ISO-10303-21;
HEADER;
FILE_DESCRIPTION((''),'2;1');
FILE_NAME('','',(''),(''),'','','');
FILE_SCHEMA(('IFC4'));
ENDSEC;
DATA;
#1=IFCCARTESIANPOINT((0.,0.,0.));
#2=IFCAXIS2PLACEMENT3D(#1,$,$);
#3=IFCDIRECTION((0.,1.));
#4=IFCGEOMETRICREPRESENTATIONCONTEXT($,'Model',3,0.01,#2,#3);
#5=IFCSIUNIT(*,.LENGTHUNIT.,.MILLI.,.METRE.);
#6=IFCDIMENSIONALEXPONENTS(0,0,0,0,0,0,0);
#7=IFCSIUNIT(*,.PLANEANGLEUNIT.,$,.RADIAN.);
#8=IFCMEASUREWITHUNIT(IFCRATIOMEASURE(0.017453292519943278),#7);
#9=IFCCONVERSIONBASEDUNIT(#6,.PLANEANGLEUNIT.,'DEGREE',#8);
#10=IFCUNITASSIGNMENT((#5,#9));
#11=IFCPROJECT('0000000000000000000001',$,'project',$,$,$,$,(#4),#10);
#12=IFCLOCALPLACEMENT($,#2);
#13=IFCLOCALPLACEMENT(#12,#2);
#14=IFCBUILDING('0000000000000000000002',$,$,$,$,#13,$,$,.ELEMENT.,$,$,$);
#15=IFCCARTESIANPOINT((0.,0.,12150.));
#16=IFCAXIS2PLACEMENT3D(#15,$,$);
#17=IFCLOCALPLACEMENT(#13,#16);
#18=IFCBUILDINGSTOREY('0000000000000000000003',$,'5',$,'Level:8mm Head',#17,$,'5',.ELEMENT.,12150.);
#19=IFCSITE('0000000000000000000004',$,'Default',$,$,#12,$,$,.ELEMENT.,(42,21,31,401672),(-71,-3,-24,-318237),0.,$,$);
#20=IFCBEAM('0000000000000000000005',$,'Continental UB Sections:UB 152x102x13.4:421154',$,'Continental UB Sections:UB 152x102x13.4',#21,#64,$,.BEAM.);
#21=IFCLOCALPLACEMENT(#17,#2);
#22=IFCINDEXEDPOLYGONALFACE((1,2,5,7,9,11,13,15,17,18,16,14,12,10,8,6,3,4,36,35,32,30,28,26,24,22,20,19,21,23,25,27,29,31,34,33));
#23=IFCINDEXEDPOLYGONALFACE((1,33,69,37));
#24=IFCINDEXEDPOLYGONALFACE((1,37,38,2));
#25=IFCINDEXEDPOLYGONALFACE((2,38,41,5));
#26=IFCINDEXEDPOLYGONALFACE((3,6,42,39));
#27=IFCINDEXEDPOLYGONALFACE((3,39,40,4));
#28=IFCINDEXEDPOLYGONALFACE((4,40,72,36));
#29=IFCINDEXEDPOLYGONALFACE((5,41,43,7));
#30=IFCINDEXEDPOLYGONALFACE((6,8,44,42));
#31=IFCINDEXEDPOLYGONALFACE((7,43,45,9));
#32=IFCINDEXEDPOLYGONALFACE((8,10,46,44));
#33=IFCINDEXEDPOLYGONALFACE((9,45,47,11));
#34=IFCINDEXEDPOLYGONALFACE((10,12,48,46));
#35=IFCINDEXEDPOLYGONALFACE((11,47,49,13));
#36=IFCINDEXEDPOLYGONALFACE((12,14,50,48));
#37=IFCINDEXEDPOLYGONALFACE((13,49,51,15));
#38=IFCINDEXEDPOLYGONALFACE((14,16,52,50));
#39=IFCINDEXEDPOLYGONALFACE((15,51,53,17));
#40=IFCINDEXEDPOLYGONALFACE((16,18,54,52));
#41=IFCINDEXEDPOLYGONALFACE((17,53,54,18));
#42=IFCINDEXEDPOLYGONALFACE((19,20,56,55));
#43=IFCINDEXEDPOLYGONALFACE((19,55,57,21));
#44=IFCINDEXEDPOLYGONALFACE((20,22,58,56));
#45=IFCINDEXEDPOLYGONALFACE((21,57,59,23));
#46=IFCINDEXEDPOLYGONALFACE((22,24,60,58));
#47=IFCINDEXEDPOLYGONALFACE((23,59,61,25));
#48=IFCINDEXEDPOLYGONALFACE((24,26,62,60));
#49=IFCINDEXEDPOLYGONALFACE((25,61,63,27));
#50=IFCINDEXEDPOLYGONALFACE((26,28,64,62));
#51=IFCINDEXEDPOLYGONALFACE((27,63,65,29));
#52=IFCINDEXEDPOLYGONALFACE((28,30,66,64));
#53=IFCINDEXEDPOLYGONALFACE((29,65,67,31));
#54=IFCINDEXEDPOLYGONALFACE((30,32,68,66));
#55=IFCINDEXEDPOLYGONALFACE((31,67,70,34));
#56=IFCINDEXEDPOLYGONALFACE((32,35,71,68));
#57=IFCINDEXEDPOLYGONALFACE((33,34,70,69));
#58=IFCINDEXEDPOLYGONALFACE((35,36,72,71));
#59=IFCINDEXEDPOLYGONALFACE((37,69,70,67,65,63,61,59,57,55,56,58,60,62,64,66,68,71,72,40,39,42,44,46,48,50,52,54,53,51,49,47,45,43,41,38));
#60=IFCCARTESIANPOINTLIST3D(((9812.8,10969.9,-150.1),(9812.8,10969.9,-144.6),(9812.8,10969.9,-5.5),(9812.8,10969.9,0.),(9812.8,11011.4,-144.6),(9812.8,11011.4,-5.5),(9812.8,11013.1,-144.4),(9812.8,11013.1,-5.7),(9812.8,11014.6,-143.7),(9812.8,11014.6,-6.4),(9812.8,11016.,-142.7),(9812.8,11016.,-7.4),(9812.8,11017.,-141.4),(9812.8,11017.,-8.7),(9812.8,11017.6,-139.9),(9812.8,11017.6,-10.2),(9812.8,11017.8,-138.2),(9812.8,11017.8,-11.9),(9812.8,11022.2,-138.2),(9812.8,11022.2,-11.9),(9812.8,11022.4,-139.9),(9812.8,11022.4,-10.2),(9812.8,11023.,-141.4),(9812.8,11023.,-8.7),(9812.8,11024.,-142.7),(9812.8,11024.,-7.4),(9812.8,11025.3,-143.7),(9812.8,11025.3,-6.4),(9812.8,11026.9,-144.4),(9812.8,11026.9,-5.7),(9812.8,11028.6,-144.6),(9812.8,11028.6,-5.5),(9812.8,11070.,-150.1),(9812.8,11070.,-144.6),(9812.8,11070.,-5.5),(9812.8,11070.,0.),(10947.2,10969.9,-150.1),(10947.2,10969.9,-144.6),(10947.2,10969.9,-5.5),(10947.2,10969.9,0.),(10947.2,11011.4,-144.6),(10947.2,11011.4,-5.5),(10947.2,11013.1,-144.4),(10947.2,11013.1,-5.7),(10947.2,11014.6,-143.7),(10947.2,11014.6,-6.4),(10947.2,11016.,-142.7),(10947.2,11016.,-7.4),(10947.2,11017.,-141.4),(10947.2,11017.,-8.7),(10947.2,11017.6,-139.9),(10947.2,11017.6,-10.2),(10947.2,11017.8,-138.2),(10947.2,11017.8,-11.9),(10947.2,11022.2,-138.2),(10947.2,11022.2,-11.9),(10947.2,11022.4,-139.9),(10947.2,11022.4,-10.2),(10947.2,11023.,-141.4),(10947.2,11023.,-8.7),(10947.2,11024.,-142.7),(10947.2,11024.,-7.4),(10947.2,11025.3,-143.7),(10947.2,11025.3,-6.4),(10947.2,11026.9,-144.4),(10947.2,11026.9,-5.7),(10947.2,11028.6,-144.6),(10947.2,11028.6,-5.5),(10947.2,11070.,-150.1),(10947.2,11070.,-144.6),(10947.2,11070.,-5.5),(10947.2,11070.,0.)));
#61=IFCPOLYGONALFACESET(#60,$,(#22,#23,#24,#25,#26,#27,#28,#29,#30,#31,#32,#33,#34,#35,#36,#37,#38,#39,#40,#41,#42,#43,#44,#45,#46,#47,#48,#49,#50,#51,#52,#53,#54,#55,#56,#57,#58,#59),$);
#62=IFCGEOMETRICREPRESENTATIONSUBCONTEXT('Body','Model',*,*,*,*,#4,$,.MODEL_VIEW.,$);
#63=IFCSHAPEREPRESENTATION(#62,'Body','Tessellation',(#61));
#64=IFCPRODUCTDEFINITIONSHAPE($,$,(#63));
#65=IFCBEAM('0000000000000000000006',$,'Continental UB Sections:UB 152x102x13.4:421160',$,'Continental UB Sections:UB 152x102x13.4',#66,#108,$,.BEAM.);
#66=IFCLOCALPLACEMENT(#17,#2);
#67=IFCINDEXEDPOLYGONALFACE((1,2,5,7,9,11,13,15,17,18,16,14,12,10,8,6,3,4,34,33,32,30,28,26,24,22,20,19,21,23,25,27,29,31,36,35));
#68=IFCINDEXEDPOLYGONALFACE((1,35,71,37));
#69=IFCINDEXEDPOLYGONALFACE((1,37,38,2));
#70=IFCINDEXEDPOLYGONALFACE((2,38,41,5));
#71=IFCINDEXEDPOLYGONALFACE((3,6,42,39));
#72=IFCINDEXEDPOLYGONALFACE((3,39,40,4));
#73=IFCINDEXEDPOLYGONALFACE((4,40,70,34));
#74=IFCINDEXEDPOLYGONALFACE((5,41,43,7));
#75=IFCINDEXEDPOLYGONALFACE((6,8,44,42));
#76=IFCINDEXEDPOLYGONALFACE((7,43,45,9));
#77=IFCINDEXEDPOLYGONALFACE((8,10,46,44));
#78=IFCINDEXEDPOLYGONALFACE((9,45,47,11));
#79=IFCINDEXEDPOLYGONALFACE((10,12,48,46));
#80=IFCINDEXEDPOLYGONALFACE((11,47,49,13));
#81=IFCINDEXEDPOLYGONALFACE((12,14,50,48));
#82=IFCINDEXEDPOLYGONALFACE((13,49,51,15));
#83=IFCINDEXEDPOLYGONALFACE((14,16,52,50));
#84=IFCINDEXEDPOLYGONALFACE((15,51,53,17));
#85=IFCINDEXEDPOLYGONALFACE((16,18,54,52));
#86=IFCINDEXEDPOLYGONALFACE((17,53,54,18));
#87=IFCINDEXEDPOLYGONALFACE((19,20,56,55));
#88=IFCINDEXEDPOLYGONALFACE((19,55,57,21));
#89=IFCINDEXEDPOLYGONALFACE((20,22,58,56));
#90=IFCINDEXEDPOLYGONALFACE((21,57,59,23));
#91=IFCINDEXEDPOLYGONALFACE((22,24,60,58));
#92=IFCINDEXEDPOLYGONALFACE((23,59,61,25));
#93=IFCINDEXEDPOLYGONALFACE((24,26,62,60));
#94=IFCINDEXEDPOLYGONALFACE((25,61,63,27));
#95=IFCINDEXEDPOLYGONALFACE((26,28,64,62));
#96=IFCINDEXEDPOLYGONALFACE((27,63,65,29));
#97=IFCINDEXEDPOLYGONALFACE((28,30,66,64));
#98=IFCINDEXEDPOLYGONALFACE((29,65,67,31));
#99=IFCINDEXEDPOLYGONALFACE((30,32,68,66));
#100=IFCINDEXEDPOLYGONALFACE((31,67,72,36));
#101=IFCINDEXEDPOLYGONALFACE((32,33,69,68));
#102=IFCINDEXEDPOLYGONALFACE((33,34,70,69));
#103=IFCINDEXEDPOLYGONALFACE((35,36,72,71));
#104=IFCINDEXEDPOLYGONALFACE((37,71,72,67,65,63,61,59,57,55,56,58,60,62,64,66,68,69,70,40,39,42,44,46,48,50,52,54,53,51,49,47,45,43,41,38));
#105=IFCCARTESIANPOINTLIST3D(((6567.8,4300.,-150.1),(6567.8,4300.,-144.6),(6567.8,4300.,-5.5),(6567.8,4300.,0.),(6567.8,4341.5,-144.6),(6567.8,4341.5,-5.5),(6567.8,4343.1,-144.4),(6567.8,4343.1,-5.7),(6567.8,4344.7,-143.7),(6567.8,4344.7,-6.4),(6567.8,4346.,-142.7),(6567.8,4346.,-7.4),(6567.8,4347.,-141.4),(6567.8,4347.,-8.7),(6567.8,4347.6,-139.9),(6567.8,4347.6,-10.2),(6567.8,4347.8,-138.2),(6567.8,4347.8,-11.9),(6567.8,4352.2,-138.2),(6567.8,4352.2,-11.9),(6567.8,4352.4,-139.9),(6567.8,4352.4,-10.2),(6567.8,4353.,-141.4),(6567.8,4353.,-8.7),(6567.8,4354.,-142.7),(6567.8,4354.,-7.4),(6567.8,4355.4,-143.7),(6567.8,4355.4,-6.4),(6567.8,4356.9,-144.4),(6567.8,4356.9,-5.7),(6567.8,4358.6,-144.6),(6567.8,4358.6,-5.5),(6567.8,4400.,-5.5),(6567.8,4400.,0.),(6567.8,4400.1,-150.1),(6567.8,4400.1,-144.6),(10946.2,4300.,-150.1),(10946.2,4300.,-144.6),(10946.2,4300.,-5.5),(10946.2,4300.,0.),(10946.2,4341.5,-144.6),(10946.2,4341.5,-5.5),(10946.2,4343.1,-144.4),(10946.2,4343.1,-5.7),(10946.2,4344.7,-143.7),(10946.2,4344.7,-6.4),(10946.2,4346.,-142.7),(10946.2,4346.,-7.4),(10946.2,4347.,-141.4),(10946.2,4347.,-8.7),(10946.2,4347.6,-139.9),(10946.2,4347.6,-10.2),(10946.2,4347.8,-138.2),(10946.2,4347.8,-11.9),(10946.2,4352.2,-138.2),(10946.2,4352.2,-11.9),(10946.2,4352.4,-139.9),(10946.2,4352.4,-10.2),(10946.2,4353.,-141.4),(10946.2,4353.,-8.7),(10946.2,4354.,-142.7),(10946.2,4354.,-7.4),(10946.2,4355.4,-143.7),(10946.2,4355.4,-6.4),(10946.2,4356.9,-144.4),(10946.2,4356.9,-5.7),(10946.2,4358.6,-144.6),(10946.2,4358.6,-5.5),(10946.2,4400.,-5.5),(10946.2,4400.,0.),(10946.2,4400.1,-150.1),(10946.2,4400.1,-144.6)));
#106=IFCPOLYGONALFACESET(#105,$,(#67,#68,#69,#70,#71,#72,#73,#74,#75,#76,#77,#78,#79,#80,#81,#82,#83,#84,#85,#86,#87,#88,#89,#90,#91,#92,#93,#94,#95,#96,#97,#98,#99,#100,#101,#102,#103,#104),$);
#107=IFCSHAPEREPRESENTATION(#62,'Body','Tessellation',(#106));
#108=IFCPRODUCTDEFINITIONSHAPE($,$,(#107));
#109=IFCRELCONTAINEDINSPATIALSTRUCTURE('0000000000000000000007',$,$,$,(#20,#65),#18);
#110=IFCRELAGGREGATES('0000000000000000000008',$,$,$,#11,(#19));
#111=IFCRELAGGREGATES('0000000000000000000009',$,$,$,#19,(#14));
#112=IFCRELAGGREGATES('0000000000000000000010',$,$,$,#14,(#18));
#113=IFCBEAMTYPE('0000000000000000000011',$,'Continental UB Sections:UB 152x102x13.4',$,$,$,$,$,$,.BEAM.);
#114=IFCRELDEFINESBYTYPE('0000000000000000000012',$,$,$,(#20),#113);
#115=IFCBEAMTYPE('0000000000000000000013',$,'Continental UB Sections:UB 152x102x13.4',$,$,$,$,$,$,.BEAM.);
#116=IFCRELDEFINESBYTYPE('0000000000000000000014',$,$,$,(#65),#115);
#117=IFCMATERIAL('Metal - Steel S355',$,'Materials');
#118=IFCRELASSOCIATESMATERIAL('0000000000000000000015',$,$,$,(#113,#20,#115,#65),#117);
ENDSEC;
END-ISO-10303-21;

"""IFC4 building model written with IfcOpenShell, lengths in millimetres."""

from ifc_helpers import new_model, entity, si_unit, converted_unit, direction, frame, origin, place, context, subcontext, project, spatial, line, arc, indexed_curve, outline, extrude, source, transform, mapped, material, type_object, type_shapes, element, save


model = new_model("IFC4")

# Units and contexts
model_context = context("Model", 3, precision=0.01, world=origin(), true_north=direction((0.0, 1.0)))
body_context = subcontext(model_context, "Body", "Model", "MODEL_VIEW")
ifc_project = project(units=[si_unit("LENGTHUNIT", "METRE", prefix="MILLI"), converted_unit("PLANEANGLEUNIT", "DEGREE", entity("IfcRatioMeasure", 0.017453292519943278), si_unit("PLANEANGLEUNIT", "RADIAN"), dimensions=[0, 0, 0, 0, 0, 0, 0])], contexts=[model_context])

# Site, building, storey
site_placement = place(None, origin())
site = spatial("IfcSite", under=ifc_project, at=site_placement, Name="Default", CompositionType="ELEMENT", RefLatitude=(42, 21, 31, 401672), RefLongitude=(-71, -3, -24, -318237), RefElevation=0.0)
building_placement = place(site_placement, origin())
building = spatial("IfcBuilding", under=site, at=building_placement, CompositionType="ELEMENT")
storey_placement = place(building_placement, frame((0.0, 0.0, 12150.0)))
storey = spatial("IfcBuildingStorey", under=building, at=storey_placement, Name="5", ObjectType="Level:8mm Head", LongName="5", CompositionType="ELEMENT", Elevation=12150.0)

# Beams
ifc_material = material(Name="Metal - Steel S355", Category="Materials")
beam_type_1 = type_object("IfcBeamType", Name="Continental UB Sections:UB 152x102x13.4", PredefinedType="BEAM", material=ifc_material)
shared_shape_1 = source(origin(), body_context, "Body", "SweptSolid", [
    extrude(outline(indexed_curve([(-75.0, -50.1), (-69.6, -50.1), (-69.6, -8.5), (-67.7, -4.0), (-63.2, -2.1), (63.1, -2.1), (67.7, -4.0), (69.5, -8.5), (69.5, -50.1), (75.1, -50.1), (75.1, 50.1), (69.5, 50.1), (69.5, 8.6), (67.7, 4.0), (63.1, 2.2), (-63.2, 2.2), (-67.7, 4.0), (-69.6, 8.6), (-69.6, 50.0), (-75.0, 50.0)], segments=[line(1, 2, 3), arc(3, 4, 5), line(5, 6), arc(6, 7, 8), line(8, 9, 10, 11, 12, 13), arc(13, 14, 15), line(15, 16), arc(16, 17, 18), line(18, 19, 20, 1)], self_intersect=False)), frame((-567.2, 0.0, 0.0), z_axis=(1.0, 0.0, 0.0), x_axis=(0.0, 0.0, -1.0)), (0.0, 0.0, 1.0), 1134.4),
])
type_shapes(beam_type_1, [shared_shape_1])
beam_1_placement = place(storey_placement, frame((10380.0, 11020.0, -75.1)))
element("IfcBeam", 1, at=beam_1_placement, inside=storey, type_object=beam_type_1, material=ifc_material, Name="Continental UB Sections:UB 152x102x13.4:421154", ObjectType="Continental UB Sections:UB 152x102x13.4", PredefinedType="BEAM", context=body_context, shape_type="MappedRepresentation", body=[
    mapped(shared_shape_1, transform((0.0, 0.0, 0.0), scale=1.0)),
])
beam_type_2 = type_object("IfcBeamType", Name="Continental UB Sections:UB 152x102x13.4", PredefinedType="BEAM", material=ifc_material)
shared_shape_2 = source(origin(), body_context, "Body", "SweptSolid", [
    extrude(outline(indexed_curve([(-75.0, -50.1), (-69.6, -50.1), (-69.6, -8.5), (-67.7, -4.0), (-63.2, -2.1), (63.1, -2.1), (67.7, -4.0), (69.5, -8.5), (69.5, -50.1), (75.1, -50.1), (75.1, 50.1), (69.5, 50.1), (69.5, 8.6), (67.7, 4.0), (63.1, 2.2), (-63.2, 2.2), (-67.7, 4.0), (-69.6, 8.6), (-69.6, 50.0), (-75.0, 50.0)], segments=[line(1, 2, 3), arc(3, 4, 5), line(5, 6), arc(6, 7, 8), line(8, 9, 10, 11, 12, 13), arc(13, 14, 15), line(15, 16), arc(16, 17, 18), line(18, 19, 20, 1)], self_intersect=False)), frame((-2189.2, 0.0, 0.0), z_axis=(1.0, 0.0, 0.0), x_axis=(0.0, 0.0, -1.0)), (0.0, 0.0, 1.0), 4378.4),
])
type_shapes(beam_type_2, [shared_shape_2])
beam_2_placement = place(storey_placement, frame((8757.0, 4350.0, -75.1)))
element("IfcBeam", 2, at=beam_2_placement, inside=storey, type_object=beam_type_2, material=ifc_material, Name="Continental UB Sections:UB 152x102x13.4:421160", ObjectType="Continental UB Sections:UB 152x102x13.4", PredefinedType="BEAM", context=body_context, shape_type="MappedRepresentation", body=[
    mapped(shared_shape_2, transform((0.0, 0.0, 0.0), scale=1.0)),
])

save(model, "model.ifc")
